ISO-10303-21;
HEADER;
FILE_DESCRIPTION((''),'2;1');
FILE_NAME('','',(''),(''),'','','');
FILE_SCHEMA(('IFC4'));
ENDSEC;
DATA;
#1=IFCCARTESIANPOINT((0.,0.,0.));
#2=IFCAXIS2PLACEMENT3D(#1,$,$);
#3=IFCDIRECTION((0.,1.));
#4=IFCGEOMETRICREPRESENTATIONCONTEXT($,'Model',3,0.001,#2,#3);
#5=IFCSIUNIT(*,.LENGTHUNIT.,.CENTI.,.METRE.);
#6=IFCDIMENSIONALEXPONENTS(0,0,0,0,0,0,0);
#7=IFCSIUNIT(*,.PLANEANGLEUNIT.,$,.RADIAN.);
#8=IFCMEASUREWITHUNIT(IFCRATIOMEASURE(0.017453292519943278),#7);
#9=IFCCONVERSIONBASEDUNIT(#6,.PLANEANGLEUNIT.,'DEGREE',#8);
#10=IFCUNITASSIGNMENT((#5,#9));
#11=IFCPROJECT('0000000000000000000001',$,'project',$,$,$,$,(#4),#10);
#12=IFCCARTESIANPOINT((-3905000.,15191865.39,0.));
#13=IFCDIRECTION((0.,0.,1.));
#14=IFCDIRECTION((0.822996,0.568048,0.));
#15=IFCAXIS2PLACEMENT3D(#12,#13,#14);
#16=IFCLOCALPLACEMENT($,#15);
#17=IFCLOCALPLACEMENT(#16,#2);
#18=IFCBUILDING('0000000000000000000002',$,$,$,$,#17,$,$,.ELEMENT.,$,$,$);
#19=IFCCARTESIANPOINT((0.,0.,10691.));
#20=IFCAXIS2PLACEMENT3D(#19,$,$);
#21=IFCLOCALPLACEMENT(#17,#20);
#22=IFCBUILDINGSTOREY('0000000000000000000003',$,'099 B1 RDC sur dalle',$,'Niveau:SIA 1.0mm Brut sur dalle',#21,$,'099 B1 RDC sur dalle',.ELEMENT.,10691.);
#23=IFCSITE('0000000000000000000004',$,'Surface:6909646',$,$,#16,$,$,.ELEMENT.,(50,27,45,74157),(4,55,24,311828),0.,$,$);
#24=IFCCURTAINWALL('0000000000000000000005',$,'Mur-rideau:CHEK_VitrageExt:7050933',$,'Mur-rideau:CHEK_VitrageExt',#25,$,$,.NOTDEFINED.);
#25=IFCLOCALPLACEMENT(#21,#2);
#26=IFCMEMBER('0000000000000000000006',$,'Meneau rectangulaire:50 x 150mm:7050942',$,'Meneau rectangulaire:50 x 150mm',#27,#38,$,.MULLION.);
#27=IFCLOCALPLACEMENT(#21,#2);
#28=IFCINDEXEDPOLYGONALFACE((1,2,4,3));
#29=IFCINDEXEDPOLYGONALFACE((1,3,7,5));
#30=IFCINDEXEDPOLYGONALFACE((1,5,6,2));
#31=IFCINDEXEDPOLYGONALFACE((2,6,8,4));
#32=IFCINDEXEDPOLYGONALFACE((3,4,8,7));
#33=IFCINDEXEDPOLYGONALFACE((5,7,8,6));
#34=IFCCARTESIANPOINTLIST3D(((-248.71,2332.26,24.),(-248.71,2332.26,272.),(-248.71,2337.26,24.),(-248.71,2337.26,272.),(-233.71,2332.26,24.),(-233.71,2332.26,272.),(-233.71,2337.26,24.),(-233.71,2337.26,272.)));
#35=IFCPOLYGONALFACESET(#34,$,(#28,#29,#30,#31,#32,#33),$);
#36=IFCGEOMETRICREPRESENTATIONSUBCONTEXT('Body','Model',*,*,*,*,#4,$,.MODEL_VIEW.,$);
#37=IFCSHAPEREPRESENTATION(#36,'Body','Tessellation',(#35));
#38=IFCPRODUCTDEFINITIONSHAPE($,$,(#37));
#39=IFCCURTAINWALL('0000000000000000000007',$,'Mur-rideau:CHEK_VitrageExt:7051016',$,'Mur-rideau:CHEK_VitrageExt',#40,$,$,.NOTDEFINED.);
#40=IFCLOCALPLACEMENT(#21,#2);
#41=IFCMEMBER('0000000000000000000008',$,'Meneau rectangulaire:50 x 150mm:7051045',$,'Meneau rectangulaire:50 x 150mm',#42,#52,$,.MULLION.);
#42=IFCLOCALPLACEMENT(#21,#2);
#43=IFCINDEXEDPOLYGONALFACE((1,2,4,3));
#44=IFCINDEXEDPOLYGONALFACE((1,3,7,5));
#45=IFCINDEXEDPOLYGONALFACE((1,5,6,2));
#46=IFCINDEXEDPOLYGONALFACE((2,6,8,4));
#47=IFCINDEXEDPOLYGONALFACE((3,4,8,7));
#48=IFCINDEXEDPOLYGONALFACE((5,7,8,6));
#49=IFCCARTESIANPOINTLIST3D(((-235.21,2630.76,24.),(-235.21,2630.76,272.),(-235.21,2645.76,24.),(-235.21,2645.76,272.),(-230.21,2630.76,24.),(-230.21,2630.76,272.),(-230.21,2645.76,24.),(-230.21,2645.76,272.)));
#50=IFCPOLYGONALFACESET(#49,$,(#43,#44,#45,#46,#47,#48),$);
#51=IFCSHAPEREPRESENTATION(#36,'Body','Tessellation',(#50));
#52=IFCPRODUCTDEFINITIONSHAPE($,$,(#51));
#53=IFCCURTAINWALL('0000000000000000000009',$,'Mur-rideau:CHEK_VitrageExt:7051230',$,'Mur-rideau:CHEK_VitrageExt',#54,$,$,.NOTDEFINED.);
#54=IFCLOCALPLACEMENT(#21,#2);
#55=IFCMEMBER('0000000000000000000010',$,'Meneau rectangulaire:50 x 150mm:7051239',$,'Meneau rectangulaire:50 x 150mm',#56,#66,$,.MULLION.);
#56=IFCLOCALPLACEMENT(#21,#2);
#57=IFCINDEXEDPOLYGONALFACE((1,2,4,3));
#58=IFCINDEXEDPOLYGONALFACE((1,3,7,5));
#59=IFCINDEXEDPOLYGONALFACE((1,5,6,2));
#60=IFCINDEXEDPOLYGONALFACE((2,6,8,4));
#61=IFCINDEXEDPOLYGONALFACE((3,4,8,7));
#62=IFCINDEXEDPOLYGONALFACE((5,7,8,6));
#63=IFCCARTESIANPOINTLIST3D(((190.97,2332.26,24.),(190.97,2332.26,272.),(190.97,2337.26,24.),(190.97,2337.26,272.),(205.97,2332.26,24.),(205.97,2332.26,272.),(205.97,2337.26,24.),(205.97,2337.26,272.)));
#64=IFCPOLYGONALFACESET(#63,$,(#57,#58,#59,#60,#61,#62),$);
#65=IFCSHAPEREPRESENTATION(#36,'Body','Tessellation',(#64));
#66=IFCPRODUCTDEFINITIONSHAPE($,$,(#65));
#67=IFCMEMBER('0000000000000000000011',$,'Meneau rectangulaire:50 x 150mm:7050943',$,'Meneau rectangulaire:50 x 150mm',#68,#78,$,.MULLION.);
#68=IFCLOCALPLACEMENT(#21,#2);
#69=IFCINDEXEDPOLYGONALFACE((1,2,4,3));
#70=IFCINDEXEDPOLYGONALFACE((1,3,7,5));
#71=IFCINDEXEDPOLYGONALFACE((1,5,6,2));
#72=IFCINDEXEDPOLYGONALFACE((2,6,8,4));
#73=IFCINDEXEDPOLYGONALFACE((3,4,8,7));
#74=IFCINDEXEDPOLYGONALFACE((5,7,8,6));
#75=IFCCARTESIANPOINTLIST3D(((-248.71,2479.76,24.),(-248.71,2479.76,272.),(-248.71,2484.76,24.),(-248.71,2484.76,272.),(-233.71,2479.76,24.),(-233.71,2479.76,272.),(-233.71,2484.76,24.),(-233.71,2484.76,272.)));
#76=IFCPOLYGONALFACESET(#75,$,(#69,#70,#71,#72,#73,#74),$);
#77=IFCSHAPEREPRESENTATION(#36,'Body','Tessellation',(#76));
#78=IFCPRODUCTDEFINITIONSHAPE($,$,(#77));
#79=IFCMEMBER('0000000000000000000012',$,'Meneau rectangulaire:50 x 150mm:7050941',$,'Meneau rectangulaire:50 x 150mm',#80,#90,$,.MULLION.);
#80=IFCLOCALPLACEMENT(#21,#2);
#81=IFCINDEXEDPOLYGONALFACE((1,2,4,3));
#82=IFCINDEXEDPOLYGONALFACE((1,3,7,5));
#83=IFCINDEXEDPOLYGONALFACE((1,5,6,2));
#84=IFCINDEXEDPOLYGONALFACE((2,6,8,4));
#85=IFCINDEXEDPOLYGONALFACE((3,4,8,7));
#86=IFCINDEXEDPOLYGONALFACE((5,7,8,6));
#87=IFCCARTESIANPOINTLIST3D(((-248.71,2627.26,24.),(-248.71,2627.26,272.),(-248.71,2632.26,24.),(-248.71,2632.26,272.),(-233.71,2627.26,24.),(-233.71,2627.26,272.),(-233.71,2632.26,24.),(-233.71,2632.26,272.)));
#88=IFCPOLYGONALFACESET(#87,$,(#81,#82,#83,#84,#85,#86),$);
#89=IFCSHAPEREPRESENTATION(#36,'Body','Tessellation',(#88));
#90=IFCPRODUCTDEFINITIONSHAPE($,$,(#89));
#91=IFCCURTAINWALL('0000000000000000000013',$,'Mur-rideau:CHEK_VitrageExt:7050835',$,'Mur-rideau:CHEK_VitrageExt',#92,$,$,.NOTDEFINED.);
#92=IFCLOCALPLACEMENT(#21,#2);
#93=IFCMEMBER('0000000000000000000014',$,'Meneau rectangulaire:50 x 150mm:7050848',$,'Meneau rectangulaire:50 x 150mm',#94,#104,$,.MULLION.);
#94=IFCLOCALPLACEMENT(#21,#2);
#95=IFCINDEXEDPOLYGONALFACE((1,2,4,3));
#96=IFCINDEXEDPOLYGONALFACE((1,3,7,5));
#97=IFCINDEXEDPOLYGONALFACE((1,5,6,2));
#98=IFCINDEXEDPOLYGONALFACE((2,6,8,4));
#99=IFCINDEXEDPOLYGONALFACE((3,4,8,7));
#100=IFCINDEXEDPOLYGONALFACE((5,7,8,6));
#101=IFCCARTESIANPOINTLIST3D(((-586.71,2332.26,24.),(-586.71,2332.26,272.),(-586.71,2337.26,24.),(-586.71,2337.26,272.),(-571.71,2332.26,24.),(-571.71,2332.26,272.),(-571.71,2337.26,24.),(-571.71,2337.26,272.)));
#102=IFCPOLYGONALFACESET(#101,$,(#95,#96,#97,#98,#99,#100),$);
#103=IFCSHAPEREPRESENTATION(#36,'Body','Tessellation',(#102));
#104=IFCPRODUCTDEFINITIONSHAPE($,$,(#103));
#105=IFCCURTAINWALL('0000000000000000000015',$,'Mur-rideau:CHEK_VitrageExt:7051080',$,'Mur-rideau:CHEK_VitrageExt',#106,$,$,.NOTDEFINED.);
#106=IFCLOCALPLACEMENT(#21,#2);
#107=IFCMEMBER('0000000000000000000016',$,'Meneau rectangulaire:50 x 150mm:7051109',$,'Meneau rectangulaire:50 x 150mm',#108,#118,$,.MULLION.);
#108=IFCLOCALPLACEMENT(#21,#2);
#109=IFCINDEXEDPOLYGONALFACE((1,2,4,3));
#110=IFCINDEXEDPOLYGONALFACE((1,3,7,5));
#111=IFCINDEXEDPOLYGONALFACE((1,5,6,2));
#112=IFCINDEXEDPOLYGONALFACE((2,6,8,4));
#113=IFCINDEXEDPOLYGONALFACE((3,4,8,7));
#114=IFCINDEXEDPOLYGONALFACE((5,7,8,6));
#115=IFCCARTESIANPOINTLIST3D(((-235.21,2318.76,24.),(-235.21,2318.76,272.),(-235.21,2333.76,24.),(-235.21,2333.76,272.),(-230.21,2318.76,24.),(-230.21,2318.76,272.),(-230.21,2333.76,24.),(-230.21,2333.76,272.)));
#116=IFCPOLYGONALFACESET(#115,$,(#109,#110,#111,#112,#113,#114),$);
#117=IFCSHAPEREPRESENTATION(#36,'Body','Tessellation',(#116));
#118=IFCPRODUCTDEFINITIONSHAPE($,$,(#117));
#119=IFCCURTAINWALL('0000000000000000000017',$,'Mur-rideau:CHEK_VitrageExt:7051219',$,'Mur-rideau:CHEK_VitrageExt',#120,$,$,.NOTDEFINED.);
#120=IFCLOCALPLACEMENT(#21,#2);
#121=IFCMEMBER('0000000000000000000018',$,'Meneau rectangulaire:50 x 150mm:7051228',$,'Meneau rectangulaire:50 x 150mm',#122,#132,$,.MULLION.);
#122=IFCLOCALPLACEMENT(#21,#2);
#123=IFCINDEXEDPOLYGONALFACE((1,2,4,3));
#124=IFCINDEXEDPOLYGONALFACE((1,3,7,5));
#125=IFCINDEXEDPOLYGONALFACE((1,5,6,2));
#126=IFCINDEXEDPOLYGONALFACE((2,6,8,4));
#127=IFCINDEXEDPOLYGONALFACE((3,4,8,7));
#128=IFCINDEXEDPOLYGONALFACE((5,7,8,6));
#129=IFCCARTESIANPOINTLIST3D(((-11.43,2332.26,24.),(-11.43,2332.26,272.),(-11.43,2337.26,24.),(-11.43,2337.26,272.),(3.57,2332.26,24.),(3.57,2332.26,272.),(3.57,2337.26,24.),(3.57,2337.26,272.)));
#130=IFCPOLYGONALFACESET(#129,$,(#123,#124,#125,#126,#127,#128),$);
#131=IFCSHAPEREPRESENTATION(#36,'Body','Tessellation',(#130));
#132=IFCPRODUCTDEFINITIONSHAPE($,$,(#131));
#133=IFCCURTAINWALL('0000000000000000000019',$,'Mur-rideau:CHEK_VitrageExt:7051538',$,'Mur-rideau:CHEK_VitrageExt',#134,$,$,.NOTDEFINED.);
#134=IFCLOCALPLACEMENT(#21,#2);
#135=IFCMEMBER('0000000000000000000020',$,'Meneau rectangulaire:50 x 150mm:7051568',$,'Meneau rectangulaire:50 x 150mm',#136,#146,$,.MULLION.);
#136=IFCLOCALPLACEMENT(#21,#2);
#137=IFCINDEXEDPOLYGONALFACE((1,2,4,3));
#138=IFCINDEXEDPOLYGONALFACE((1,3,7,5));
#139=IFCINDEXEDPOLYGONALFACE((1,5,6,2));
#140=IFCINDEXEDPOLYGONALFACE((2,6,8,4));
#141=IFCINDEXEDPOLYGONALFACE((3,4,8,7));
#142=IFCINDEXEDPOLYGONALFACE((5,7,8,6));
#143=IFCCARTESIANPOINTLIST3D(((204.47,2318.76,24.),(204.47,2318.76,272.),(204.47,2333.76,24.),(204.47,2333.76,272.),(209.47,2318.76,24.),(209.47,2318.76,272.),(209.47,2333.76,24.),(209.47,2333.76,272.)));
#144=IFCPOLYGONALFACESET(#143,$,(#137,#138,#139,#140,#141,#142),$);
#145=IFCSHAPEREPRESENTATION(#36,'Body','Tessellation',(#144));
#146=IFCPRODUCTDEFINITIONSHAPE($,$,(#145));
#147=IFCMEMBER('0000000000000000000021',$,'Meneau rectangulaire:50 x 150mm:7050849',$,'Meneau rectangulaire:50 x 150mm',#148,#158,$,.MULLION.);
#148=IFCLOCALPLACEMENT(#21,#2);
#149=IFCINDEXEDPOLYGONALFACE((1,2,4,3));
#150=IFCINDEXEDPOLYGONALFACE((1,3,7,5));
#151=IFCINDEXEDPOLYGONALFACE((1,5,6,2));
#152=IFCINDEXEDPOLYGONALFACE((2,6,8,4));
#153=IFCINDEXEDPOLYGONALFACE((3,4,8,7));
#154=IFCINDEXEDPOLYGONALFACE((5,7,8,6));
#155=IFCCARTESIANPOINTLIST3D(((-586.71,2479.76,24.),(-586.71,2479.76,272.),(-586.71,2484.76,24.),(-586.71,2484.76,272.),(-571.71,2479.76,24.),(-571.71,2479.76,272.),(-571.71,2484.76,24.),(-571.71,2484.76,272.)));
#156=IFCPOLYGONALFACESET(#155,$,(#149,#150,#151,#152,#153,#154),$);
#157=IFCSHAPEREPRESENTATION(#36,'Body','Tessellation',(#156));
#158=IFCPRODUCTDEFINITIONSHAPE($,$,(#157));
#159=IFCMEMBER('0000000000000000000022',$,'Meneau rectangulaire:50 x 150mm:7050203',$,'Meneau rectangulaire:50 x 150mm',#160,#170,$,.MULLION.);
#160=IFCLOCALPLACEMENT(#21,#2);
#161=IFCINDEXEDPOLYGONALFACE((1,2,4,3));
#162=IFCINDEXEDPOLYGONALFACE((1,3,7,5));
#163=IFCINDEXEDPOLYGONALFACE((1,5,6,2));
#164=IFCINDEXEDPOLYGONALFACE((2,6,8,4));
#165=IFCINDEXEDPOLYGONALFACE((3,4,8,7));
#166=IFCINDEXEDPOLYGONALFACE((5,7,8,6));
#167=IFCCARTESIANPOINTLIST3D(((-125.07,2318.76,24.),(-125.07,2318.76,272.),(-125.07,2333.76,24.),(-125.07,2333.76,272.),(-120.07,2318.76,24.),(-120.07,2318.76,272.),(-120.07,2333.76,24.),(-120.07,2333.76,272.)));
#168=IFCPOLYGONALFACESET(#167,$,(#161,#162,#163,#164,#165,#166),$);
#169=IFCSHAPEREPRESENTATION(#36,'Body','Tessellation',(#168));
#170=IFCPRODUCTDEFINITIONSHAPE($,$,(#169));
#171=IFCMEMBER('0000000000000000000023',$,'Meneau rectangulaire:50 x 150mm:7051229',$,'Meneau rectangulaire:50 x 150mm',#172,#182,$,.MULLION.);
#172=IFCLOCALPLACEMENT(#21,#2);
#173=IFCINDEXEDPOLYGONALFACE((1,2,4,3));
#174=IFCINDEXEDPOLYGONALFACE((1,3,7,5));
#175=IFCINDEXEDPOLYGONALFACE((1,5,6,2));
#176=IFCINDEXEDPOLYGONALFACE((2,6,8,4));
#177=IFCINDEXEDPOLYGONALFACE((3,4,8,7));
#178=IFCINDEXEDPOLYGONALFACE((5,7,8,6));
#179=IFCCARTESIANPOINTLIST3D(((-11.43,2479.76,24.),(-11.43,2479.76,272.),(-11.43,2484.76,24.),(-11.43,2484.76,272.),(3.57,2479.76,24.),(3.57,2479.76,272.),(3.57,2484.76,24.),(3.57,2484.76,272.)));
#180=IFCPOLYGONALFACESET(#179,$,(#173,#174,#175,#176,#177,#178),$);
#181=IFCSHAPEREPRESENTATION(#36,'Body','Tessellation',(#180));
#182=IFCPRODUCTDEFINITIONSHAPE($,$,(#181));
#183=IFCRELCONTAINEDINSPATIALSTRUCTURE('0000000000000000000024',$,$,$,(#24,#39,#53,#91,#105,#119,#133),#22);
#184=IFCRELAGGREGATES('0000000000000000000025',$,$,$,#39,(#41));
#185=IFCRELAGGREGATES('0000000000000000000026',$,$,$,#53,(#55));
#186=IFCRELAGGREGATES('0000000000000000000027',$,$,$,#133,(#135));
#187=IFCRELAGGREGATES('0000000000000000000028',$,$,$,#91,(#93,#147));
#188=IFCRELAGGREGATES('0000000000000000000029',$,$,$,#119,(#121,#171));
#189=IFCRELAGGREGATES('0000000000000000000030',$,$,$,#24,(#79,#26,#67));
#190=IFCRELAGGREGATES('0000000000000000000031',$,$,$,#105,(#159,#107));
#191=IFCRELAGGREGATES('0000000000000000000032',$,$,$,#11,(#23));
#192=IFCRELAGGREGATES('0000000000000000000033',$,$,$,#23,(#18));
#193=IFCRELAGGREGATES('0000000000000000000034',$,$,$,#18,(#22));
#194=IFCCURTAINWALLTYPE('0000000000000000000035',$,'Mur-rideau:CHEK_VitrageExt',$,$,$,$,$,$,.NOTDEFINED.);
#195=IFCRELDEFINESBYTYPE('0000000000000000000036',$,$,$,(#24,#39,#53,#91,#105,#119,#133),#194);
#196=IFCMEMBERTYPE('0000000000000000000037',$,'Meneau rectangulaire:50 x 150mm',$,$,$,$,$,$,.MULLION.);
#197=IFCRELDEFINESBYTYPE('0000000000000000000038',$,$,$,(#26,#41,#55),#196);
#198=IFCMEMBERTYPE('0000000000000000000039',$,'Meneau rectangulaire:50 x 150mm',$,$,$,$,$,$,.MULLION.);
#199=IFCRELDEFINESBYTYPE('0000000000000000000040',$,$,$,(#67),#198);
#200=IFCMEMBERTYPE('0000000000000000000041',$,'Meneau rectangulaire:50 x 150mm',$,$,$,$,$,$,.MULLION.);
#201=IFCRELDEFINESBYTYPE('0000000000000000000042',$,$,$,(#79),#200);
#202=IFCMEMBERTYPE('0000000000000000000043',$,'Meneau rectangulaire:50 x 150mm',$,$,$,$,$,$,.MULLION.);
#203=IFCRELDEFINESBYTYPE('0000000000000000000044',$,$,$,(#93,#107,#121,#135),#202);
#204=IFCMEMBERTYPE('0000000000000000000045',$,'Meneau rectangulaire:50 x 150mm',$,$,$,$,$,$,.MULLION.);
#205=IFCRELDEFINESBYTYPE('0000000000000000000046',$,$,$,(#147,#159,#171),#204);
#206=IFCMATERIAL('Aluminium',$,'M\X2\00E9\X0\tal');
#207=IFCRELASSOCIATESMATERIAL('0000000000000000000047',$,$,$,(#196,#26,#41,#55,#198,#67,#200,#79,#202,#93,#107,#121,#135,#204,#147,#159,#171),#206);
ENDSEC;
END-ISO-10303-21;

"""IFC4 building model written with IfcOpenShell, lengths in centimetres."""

from ifc_helpers import new_model, entity, si_unit, converted_unit, direction, frame, origin, place, context, subcontext, project, spatial, indexed_curve, outline, extrude, source, transform, mapped, material, type_object, type_shapes, element, aggregate, save


model = new_model("IFC4")

# Units and contexts
model_context = context("Model", 3, precision=0.001, world=origin(), true_north=direction((0.0, 1.0)))
body_context = subcontext(model_context, "Body", "Model", "MODEL_VIEW")
ifc_project = project(units=[si_unit("LENGTHUNIT", "METRE", prefix="CENTI"), converted_unit("PLANEANGLEUNIT", "DEGREE", entity("IfcRatioMeasure", 0.017453292519943278), si_unit("PLANEANGLEUNIT", "RADIAN"), dimensions=[0, 0, 0, 0, 0, 0, 0])], contexts=[model_context])

# Site, building, storey
site_placement = place(None, frame((-3905000.0, 15191865.39, 0.0), z_axis=(0.0, 0.0, 1.0), x_axis=(0.822996, 0.568048, 0.0)))
site = spatial("IfcSite", under=ifc_project, at=site_placement, Name="Surface:6909646", CompositionType="ELEMENT", RefLatitude=(50, 27, 45, 74157), RefLongitude=(4, 55, 24, 311828), RefElevation=0.0)
building_placement = place(site_placement, origin())
building = spatial("IfcBuilding", under=site, at=building_placement, CompositionType="ELEMENT")
storey_placement = place(building_placement, frame((0.0, 0.0, 10691.0)))
storey = spatial("IfcBuildingStorey", under=building, at=storey_placement, Name="099 B1 RDC sur dalle", ObjectType="Niveau:SIA 1.0mm Brut sur dalle", LongName="099 B1 RDC sur dalle", CompositionType="ELEMENT", Elevation=10691.0)

# Curtain walls, members
curtain_wall_type = type_object("IfcCurtainWallType", Name="Mur-rideau:CHEK_VitrageExt", PredefinedType="NOTDEFINED")
curtain_wall_1_placement = place(storey_placement, frame((0.0, 0.0, -10691.0)))
curtain_wall_1 = element("IfcCurtainWall", 1, at=curtain_wall_1_placement, inside=storey, type_object=curtain_wall_type, Name="Mur-rideau:CHEK_VitrageExt:7050933", ObjectType="Mur-rideau:CHEK_VitrageExt", PredefinedType="NOTDEFINED")
ifc_material_1 = material(Name="Aluminium", Category="Métal")
member_type_1 = type_object("IfcMemberType", Name="Meneau rectangulaire:50 x 150mm", PredefinedType="MULLION", material=ifc_material_1)
shared_shape_1 = source(origin(), body_context, "Body", "SweptSolid", [
    extrude(outline(indexed_curve([(-7.5, -2.5), (7.5, -2.5), (7.5, 2.5), (-7.5, 2.5), (-7.5, -2.5)], self_intersect=False)), frame((-2.5, -6.0, -248.0), z_axis=(0.0, 0.0, 1.0), x_axis=(0.0, -1.0, 0.0)), (0.0, 0.0, 1.0), 248.0),
])
type_shapes(member_type_1, [shared_shape_1])
member_1_placement = place(curtain_wall_1_placement, frame((-235.21, 2332.26, 10963.0), z_axis=(0.0, 0.0, 1.0), x_axis=(0.0, -1.0, 0.0)))
member_1 = element("IfcMember", 2, at=member_1_placement, type_object=member_type_1, material=ifc_material_1, Name="Meneau rectangulaire:50 x 150mm:7050942", ObjectType="Meneau rectangulaire:50 x 150mm", PredefinedType="MULLION", context=body_context, shape_type="MappedRepresentation", body=[
    mapped(shared_shape_1, transform((0.0, 0.0, 0.0), scale=1.0)),
])
curtain_wall_2_placement = place(storey_placement, frame((0.0, 0.0, -10691.0)))
curtain_wall_2 = element("IfcCurtainWall", 3, at=curtain_wall_2_placement, inside=storey, type_object=curtain_wall_type, Name="Mur-rideau:CHEK_VitrageExt:7051016", ObjectType="Mur-rideau:CHEK_VitrageExt", PredefinedType="NOTDEFINED")
member_2_placement = place(curtain_wall_2_placement, frame((-235.21, 2632.26, 10963.0), z_axis=(0.0, 0.0, 1.0), x_axis=(-1.0, 0.0, 0.0)))
member_2 = element("IfcMember", 4, at=member_2_placement, type_object=member_type_1, material=ifc_material_1, Name="Meneau rectangulaire:50 x 150mm:7051045", ObjectType="Meneau rectangulaire:50 x 150mm", PredefinedType="MULLION", context=body_context, shape_type="MappedRepresentation", body=[
    mapped(shared_shape_1, transform((0.0, 0.0, 0.0), scale=1.0)),
])
aggregate(curtain_wall_2, [member_2])
curtain_wall_3_placement = place(storey_placement, frame((0.0, 0.0, -10691.0)))
curtain_wall_3 = element("IfcCurtainWall", 5, at=curtain_wall_3_placement, inside=storey, type_object=curtain_wall_type, Name="Mur-rideau:CHEK_VitrageExt:7051230", ObjectType="Mur-rideau:CHEK_VitrageExt", PredefinedType="NOTDEFINED")
member_3_placement = place(curtain_wall_3_placement, frame((204.47, 2332.26, 10963.0), z_axis=(0.0, 0.0, 1.0), x_axis=(0.0, -1.0, 0.0)))
member_3 = element("IfcMember", 6, at=member_3_placement, type_object=member_type_1, material=ifc_material_1, Name="Meneau rectangulaire:50 x 150mm:7051239", ObjectType="Meneau rectangulaire:50 x 150mm", PredefinedType="MULLION", context=body_context, shape_type="MappedRepresentation", body=[
    mapped(shared_shape_1, transform((0.0, 0.0, 0.0), scale=1.0)),
])
aggregate(curtain_wall_3, [member_3])

# Members
member_type_2 = type_object("IfcMemberType", Name="Meneau rectangulaire:50 x 150mm", PredefinedType="MULLION", material=ifc_material_1)
shared_shape_2 = source(origin(), body_context, "Body", "SweptSolid", [
    extrude(outline(indexed_curve([(-7.5, -2.5), (7.5, -2.5), (7.5, 2.5), (-7.5, 2.5), (-7.5, -2.5)], self_intersect=False)), frame((0.0, -6.0, -248.0), z_axis=(0.0, 0.0, 1.0), x_axis=(0.0, -1.0, 0.0)), (0.0, 0.0, 1.0), 248.0),
])
type_shapes(member_type_2, [shared_shape_2])
member_4_placement = place(curtain_wall_1_placement, frame((-235.21, 2482.26, 10715.0), z_axis=(0.0, 0.0, -1.0), x_axis=(0.0, 1.0, 0.0)))
member_4 = element("IfcMember", 7, at=member_4_placement, type_object=member_type_2, material=ifc_material_1, Name="Meneau rectangulaire:50 x 150mm:7050943", ObjectType="Meneau rectangulaire:50 x 150mm", PredefinedType="MULLION", context=body_context, shape_type="MappedRepresentation", body=[
    mapped(shared_shape_2, transform((0.0, 0.0, 0.0), scale=1.0)),
])
member_type_3 = type_object("IfcMemberType", Name="Meneau rectangulaire:50 x 150mm", PredefinedType="MULLION", material=ifc_material_1)
shared_shape_3 = source(origin(), body_context, "Body", "SweptSolid", [
    extrude(outline(indexed_curve([(-7.5, -2.5), (7.5, -2.5), (7.5, 2.5), (-7.5, 2.5), (-7.5, -2.5)], self_intersect=False)), frame((-2.5, -6.0, -248.0), z_axis=(0.0, 0.0, 1.0), x_axis=(0.0, -1.0, 0.0)), (0.0, 0.0, 1.0), 248.0),
])
type_shapes(member_type_3, [shared_shape_3])
member_5_placement = place(curtain_wall_1_placement, frame((-235.21, 2632.26, 10715.0), z_axis=(0.0, 0.0, -1.0), x_axis=(0.0, 1.0, 0.0)))
member_5 = element("IfcMember", 8, at=member_5_placement, type_object=member_type_3, material=ifc_material_1, Name="Meneau rectangulaire:50 x 150mm:7050941", ObjectType="Meneau rectangulaire:50 x 150mm", PredefinedType="MULLION", context=body_context, shape_type="MappedRepresentation", body=[
    mapped(shared_shape_3, transform((0.0, 0.0, 0.0), scale=1.0)),
])

# Curtain walls, members
curtain_wall_4_placement = place(storey_placement, frame((0.0, 0.0, -10691.0)))
curtain_wall_4 = element("IfcCurtainWall", 9, at=curtain_wall_4_placement, inside=storey, type_object=curtain_wall_type, Name="Mur-rideau:CHEK_VitrageExt:7050835", ObjectType="Mur-rideau:CHEK_VitrageExt", PredefinedType="NOTDEFINED")
member_type_4 = type_object("IfcMemberType", Name="Meneau rectangulaire:50 x 150mm", PredefinedType="MULLION", material=ifc_material_1)
shared_shape_4 = source(origin(), body_context, "Body", "SweptSolid", [
    extrude(outline(indexed_curve([(-7.5, -2.5), (7.5, -2.5), (7.5, 2.5), (-7.5, 2.5), (-7.5, -2.5)], self_intersect=False)), frame((-2.5, 6.0, -248.0), z_axis=(0.0, 0.0, 1.0), x_axis=(0.0, -1.0, 0.0)), (0.0, 0.0, 1.0), 248.0),
])
type_shapes(member_type_4, [shared_shape_4])
member_6_placement = place(curtain_wall_4_placement, frame((-585.21, 2332.26, 10963.0), z_axis=(0.0, 0.0, 1.0), x_axis=(0.0, -1.0, 0.0)))
member_6 = element("IfcMember", 10, at=member_6_placement, type_object=member_type_4, material=ifc_material_1, Name="Meneau rectangulaire:50 x 150mm:7050848", ObjectType="Meneau rectangulaire:50 x 150mm", PredefinedType="MULLION", context=body_context, shape_type="MappedRepresentation", body=[
    mapped(shared_shape_4, transform((0.0, 0.0, 0.0), scale=1.0)),
])
curtain_wall_5_placement = place(storey_placement, frame((0.0, 0.0, -10691.0)))
curtain_wall_5 = element("IfcCurtainWall", 11, at=curtain_wall_5_placement, inside=storey, type_object=curtain_wall_type, Name="Mur-rideau:CHEK_VitrageExt:7051080", ObjectType="Mur-rideau:CHEK_VitrageExt", PredefinedType="NOTDEFINED")
member_7_placement = place(curtain_wall_5_placement, frame((-235.21, 2332.26, 10963.0), z_axis=(0.0, 0.0, 1.0), x_axis=(-1.0, 0.0, 0.0)))
member_7 = element("IfcMember", 12, at=member_7_placement, type_object=member_type_4, material=ifc_material_1, Name="Meneau rectangulaire:50 x 150mm:7051109", ObjectType="Meneau rectangulaire:50 x 150mm", PredefinedType="MULLION", context=body_context, shape_type="MappedRepresentation", body=[
    mapped(shared_shape_4, transform((0.0, 0.0, 0.0), scale=1.0)),
])
curtain_wall_6_placement = place(storey_placement, frame((0.0, 0.0, -10691.0)))
curtain_wall_6 = element("IfcCurtainWall", 13, at=curtain_wall_6_placement, inside=storey, type_object=curtain_wall_type, Name="Mur-rideau:CHEK_VitrageExt:7051219", ObjectType="Mur-rideau:CHEK_VitrageExt", PredefinedType="NOTDEFINED")
member_8_placement = place(curtain_wall_6_placement, frame((-9.93, 2332.26, 10963.0), z_axis=(0.0, 0.0, 1.0), x_axis=(0.0, -1.0, 0.0)))
member_8 = element("IfcMember", 14, at=member_8_placement, type_object=member_type_4, material=ifc_material_1, Name="Meneau rectangulaire:50 x 150mm:7051228", ObjectType="Meneau rectangulaire:50 x 150mm", PredefinedType="MULLION", context=body_context, shape_type="MappedRepresentation", body=[
    mapped(shared_shape_4, transform((0.0, 0.0, 0.0), scale=1.0)),
])
curtain_wall_7_placement = place(storey_placement, frame((0.0, 0.0, -10691.0)))
curtain_wall_7 = element("IfcCurtainWall", 15, at=curtain_wall_7_placement, inside=storey, type_object=curtain_wall_type, Name="Mur-rideau:CHEK_VitrageExt:7051538", ObjectType="Mur-rideau:CHEK_VitrageExt", PredefinedType="NOTDEFINED")
member_9_placement = place(curtain_wall_7_placement, frame((204.47, 2332.26, 10963.0), z_axis=(0.0, 0.0, 1.0), x_axis=(-1.0, 0.0, 0.0)))
member_9 = element("IfcMember", 16, at=member_9_placement, type_object=member_type_4, material=ifc_material_1, Name="Meneau rectangulaire:50 x 150mm:7051568", ObjectType="Meneau rectangulaire:50 x 150mm", PredefinedType="MULLION", context=body_context, shape_type="MappedRepresentation", body=[
    mapped(shared_shape_4, transform((0.0, 0.0, 0.0), scale=1.0)),
])
aggregate(curtain_wall_7, [member_9])

# Members
member_type_5 = type_object("IfcMemberType", Name="Meneau rectangulaire:50 x 150mm", PredefinedType="MULLION", material=ifc_material_1)
shared_shape_5 = source(origin(), body_context, "Body", "SweptSolid", [
    extrude(outline(indexed_curve([(-7.5, -2.5), (7.5, -2.5), (7.5, 2.5), (-7.5, 2.5), (-7.5, -2.5)], self_intersect=False)), frame((0.0, 6.0, -248.0), z_axis=(0.0, 0.0, 1.0), x_axis=(0.0, -1.0, 0.0)), (0.0, 0.0, 1.0), 248.0),
])
type_shapes(member_type_5, [shared_shape_5])
member_10_placement = place(curtain_wall_4_placement, frame((-585.21, 2482.26, 10715.0), z_axis=(0.0, 0.0, -1.0), x_axis=(0.0, 1.0, 0.0)))
member_10 = element("IfcMember", 17, at=member_10_placement, type_object=member_type_5, material=ifc_material_1, Name="Meneau rectangulaire:50 x 150mm:7050849", ObjectType="Meneau rectangulaire:50 x 150mm", PredefinedType="MULLION", context=body_context, shape_type="MappedRepresentation", body=[
    mapped(shared_shape_5, transform((0.0, 0.0, 0.0), scale=1.0)),
])
member_11_placement = place(curtain_wall_5_placement, frame((-122.57, 2332.26, 10715.0), z_axis=(0.0, 0.0, -1.0), x_axis=(1.0, 0.0, 0.0)))
member_11 = element("IfcMember", 18, at=member_11_placement, type_object=member_type_5, material=ifc_material_1, Name="Meneau rectangulaire:50 x 150mm:7050203", ObjectType="Meneau rectangulaire:50 x 150mm", PredefinedType="MULLION", context=body_context, shape_type="MappedRepresentation", body=[
    mapped(shared_shape_5, transform((0.0, 0.0, 0.0), scale=1.0)),
])
member_12_placement = place(curtain_wall_6_placement, frame((-9.93, 2482.26, 10715.0), z_axis=(0.0, 0.0, -1.0), x_axis=(0.0, 1.0, 0.0)))
member_12 = element("IfcMember", 19, at=member_12_placement, type_object=member_type_5, material=ifc_material_1, Name="Meneau rectangulaire:50 x 150mm:7051229", ObjectType="Meneau rectangulaire:50 x 150mm", PredefinedType="MULLION", context=body_context, shape_type="MappedRepresentation", body=[
    mapped(shared_shape_5, transform((0.0, 0.0, 0.0), scale=1.0)),
])

aggregate(curtain_wall_4, [member_6, member_10])
aggregate(curtain_wall_6, [member_8, member_12])
aggregate(curtain_wall_1, [member_5, member_1, member_4])
aggregate(curtain_wall_5, [member_11, member_7])

save(model, "model.ifc")
